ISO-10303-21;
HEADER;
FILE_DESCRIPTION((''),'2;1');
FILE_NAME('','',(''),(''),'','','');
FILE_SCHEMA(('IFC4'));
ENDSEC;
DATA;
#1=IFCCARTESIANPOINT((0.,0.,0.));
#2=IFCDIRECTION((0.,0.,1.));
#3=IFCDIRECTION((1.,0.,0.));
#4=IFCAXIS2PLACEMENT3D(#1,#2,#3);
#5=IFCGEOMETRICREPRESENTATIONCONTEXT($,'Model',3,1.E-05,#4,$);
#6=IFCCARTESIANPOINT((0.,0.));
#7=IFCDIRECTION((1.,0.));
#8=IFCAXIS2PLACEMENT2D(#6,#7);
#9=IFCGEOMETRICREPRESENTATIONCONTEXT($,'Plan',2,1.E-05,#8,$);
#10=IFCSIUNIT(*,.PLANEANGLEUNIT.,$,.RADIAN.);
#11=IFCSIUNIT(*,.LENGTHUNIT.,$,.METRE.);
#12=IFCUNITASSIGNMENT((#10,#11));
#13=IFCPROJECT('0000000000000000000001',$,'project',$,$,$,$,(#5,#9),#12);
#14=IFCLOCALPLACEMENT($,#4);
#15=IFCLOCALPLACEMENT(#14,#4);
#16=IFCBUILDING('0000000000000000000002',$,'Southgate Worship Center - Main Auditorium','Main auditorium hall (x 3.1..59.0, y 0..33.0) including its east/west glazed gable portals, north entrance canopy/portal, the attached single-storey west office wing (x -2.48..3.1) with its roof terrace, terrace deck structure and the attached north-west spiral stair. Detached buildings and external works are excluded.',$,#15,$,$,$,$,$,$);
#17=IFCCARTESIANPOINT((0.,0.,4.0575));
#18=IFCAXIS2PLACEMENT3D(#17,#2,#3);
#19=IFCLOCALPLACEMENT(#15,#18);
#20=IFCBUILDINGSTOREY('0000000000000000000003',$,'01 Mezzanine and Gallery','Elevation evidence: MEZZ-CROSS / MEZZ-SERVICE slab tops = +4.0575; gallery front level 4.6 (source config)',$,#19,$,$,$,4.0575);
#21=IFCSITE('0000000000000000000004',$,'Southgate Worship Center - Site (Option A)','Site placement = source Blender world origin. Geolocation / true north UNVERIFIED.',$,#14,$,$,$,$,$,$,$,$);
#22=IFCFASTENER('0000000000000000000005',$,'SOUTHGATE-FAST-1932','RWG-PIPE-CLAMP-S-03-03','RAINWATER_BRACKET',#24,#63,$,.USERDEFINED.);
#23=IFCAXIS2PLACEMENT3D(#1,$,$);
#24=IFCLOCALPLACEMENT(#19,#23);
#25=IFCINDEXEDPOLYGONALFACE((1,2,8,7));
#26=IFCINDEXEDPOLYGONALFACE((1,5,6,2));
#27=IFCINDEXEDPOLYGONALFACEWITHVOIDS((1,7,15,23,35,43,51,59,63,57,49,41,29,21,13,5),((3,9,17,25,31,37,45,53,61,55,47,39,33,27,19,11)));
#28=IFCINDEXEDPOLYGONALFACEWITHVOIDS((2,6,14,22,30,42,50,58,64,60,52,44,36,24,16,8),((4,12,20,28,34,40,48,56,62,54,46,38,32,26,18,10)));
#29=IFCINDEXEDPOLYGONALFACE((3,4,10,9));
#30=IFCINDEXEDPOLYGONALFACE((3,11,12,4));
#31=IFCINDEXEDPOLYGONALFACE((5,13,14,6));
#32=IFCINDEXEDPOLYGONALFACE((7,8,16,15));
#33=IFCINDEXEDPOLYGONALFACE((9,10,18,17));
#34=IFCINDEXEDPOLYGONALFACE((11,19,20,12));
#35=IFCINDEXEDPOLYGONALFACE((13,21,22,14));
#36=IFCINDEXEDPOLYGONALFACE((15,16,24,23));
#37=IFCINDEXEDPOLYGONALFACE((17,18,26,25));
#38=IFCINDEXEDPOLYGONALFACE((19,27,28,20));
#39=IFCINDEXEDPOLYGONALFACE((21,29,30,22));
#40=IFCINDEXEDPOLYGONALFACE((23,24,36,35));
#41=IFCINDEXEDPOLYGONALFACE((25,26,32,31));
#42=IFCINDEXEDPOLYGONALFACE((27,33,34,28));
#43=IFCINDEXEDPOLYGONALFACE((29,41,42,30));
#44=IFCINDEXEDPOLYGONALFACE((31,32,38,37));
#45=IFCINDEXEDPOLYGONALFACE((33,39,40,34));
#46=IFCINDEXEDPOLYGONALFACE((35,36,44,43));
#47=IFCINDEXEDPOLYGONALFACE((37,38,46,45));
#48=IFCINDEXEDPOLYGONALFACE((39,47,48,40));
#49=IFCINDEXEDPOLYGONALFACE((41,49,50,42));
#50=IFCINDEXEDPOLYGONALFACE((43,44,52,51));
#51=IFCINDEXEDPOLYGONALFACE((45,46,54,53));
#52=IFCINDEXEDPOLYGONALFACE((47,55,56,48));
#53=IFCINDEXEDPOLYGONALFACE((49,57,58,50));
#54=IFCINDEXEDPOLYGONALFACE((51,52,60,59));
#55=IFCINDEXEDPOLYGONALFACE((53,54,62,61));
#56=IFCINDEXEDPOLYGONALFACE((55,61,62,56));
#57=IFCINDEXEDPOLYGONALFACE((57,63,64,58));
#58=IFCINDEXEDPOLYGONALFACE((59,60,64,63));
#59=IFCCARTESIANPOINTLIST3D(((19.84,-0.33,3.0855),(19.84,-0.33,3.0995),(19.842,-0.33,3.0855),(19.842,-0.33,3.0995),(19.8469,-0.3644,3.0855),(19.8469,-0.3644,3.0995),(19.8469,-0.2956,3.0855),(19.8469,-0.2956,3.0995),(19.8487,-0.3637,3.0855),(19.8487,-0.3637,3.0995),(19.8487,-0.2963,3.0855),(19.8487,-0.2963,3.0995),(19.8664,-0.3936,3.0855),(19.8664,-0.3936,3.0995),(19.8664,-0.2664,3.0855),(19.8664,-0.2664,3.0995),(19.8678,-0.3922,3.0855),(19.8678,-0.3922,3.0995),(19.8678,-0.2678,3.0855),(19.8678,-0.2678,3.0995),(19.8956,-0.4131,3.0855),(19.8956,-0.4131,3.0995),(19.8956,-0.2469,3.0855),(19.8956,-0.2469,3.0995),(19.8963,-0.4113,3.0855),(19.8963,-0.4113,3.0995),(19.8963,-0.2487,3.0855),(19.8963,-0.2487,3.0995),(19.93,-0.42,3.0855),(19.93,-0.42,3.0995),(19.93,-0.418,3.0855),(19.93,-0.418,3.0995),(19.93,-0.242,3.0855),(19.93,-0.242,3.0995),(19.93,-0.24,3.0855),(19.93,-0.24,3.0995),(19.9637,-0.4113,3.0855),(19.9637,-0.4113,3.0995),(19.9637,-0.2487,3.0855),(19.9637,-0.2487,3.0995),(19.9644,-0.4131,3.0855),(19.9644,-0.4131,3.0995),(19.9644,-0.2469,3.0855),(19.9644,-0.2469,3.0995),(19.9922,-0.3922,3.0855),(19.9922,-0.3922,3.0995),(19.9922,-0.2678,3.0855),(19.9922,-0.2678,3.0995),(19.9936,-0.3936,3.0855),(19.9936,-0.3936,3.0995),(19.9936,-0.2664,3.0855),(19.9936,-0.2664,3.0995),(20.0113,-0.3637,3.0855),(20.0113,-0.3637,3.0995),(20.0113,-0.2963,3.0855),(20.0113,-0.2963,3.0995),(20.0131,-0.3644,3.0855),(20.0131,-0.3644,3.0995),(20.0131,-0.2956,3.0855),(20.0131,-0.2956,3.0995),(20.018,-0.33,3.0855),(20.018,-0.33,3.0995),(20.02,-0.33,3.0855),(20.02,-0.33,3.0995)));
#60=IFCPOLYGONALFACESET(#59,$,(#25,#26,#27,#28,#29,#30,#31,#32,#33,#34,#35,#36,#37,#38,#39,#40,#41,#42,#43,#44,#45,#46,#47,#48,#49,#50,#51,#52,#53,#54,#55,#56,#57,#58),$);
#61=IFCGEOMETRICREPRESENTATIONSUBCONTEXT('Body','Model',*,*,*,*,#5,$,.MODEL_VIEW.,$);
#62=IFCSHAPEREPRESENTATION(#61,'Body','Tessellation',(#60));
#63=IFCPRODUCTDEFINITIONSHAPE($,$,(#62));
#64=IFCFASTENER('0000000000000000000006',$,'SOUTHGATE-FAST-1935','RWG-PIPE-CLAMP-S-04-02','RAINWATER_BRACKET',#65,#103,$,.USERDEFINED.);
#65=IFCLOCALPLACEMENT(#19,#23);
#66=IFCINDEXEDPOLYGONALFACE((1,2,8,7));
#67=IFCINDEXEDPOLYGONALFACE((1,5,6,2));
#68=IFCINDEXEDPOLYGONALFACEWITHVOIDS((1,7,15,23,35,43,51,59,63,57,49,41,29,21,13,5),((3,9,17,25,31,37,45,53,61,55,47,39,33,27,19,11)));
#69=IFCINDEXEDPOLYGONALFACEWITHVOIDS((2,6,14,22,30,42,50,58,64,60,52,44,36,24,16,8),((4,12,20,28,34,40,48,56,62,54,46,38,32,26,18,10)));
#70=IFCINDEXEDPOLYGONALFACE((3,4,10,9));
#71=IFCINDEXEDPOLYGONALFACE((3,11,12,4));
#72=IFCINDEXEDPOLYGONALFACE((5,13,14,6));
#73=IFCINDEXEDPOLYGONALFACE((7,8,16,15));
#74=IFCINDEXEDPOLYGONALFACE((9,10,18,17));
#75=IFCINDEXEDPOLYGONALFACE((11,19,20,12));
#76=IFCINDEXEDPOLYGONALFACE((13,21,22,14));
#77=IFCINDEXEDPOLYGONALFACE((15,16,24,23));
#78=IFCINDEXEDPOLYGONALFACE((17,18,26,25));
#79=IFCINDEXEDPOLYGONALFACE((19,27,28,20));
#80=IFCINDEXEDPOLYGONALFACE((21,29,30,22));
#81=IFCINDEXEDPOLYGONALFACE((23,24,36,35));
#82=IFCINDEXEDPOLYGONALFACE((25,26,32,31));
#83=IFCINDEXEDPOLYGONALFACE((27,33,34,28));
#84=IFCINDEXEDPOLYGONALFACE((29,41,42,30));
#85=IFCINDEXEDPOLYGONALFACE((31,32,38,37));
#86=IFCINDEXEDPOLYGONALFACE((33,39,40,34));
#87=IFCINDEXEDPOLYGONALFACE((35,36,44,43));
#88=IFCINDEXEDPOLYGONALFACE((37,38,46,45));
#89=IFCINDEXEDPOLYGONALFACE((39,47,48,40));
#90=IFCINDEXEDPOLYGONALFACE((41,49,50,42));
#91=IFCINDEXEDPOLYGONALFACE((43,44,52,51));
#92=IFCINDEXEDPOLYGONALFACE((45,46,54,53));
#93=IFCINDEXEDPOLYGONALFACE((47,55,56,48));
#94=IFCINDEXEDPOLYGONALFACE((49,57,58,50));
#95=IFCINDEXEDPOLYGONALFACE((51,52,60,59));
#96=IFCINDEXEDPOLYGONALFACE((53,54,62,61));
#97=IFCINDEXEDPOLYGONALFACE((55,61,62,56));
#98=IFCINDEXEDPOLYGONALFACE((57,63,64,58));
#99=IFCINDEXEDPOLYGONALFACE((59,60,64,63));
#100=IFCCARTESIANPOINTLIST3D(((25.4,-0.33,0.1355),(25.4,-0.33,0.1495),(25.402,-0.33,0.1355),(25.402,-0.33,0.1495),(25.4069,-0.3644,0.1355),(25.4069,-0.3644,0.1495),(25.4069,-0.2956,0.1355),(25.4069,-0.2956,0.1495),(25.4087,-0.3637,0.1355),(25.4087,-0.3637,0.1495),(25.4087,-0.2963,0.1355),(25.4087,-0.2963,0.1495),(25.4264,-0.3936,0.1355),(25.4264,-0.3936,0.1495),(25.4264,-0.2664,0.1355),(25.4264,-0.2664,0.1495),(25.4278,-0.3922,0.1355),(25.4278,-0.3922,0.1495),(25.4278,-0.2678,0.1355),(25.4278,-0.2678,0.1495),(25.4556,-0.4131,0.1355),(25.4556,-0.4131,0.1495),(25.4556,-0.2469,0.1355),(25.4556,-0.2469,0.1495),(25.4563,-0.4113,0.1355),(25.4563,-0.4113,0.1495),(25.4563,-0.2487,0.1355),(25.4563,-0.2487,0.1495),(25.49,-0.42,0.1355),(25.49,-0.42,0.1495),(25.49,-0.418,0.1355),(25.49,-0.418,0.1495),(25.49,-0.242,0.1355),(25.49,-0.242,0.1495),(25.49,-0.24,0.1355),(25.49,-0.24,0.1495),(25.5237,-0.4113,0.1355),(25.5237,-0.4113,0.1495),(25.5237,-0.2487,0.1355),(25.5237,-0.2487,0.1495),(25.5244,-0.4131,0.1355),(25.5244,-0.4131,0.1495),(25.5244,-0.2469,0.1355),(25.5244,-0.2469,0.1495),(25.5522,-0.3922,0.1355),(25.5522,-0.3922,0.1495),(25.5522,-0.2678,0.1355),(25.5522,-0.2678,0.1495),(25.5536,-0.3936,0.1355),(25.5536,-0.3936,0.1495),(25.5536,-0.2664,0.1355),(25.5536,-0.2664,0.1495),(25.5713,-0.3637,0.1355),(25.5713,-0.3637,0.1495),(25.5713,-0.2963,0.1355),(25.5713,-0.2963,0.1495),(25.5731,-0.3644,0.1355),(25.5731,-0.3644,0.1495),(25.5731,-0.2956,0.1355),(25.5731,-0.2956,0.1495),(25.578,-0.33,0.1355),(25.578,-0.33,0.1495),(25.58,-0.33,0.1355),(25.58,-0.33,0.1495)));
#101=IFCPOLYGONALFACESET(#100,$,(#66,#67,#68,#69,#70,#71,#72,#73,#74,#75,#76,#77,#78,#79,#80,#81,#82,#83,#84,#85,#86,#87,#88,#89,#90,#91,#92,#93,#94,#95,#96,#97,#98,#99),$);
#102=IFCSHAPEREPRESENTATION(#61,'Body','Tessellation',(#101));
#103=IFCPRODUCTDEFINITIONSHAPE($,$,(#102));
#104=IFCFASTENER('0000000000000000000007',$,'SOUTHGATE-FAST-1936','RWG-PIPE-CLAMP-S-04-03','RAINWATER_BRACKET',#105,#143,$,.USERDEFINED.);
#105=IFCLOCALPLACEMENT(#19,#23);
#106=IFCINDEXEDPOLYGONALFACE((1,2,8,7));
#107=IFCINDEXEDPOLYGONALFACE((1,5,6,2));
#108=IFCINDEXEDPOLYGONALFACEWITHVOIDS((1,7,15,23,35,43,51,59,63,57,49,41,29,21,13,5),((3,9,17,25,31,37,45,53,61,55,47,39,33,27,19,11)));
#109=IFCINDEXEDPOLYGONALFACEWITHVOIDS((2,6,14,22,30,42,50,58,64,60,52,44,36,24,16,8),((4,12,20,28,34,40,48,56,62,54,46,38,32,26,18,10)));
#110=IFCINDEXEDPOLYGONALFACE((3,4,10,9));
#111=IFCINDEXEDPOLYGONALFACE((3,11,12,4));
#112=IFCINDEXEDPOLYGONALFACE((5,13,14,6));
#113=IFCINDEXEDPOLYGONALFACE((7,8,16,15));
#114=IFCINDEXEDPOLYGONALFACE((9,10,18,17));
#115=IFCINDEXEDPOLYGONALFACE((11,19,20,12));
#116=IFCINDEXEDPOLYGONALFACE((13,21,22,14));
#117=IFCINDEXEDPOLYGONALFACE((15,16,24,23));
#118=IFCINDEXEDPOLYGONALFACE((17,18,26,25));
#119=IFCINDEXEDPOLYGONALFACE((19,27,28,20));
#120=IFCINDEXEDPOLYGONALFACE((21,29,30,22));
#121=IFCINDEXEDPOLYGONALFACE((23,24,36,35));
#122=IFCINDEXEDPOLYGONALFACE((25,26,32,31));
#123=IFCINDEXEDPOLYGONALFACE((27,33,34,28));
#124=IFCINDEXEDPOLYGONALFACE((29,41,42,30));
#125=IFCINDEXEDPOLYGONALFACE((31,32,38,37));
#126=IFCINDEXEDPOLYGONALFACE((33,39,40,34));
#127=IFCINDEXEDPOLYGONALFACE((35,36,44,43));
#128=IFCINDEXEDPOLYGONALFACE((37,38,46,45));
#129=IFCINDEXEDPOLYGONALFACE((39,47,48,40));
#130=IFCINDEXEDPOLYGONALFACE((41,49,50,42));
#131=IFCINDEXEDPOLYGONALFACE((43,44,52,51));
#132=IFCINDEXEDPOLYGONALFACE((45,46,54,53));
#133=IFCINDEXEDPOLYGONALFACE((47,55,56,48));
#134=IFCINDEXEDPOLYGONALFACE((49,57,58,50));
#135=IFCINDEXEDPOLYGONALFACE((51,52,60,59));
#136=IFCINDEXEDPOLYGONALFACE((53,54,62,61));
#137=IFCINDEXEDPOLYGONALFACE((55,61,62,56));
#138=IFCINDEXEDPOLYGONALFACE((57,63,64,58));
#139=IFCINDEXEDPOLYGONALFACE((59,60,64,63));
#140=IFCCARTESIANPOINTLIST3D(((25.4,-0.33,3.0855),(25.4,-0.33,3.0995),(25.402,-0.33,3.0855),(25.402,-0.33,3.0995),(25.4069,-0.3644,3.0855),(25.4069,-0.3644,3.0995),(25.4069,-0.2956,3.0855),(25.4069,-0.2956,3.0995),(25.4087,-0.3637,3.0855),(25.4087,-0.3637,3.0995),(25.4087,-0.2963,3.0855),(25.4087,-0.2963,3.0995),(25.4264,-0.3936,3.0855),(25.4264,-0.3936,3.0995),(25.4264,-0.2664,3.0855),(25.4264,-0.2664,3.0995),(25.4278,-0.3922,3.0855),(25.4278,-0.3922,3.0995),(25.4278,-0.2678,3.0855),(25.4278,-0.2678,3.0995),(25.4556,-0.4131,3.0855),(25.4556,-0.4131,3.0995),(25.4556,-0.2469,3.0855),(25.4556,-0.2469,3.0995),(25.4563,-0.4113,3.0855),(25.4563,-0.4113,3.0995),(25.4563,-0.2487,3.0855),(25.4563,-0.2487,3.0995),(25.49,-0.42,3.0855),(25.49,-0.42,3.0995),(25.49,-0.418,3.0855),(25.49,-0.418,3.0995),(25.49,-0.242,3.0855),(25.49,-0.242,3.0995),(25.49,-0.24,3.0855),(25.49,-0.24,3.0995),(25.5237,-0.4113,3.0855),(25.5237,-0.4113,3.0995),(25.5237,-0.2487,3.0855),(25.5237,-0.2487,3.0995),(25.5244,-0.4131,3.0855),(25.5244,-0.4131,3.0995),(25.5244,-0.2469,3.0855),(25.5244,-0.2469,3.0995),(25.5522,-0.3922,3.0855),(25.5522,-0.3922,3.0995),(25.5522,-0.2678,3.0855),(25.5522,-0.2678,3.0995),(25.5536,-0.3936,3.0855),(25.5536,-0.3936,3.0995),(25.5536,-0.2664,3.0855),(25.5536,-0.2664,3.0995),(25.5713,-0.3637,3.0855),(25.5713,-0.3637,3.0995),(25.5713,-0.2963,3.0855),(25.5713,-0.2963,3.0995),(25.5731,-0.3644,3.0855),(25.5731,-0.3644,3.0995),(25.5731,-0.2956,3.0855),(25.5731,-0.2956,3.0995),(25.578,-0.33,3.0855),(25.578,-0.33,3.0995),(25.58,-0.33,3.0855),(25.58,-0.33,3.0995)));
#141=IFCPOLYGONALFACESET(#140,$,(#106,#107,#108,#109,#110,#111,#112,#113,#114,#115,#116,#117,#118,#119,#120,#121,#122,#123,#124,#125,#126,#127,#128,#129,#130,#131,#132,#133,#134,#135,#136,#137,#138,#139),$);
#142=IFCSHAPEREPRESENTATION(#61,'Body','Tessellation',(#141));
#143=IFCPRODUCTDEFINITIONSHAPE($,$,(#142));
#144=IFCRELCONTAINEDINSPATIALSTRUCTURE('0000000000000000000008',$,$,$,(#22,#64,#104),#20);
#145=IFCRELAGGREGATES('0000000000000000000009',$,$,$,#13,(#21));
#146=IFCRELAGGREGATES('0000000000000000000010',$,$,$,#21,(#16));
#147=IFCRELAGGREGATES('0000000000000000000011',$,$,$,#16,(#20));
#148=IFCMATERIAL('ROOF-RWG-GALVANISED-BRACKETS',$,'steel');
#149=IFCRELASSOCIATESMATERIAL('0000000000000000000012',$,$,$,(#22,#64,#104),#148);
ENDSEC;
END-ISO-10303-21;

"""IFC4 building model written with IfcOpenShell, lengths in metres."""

from ifc_helpers import new_model, si_unit, frame, origin_with_axes, origin_2d_with_axis, place, context, subcontext, project, spatial, indexed_curve, outline, extrude, material, element, save


model = new_model("IFC4")

# Units and contexts
model_context = context("Model", 3, precision=1e-05, world=origin_with_axes())
plan_context = context("Plan", 2, precision=1e-05, world=origin_2d_with_axis())
body_context = subcontext(model_context, "Body", "Model", "MODEL_VIEW")
ifc_project = project(units=[si_unit("PLANEANGLEUNIT", "RADIAN"), si_unit("LENGTHUNIT", "METRE")], contexts=[model_context, plan_context])

# Site, building, storey
site_placement = place(None, origin_with_axes())
site = spatial("IfcSite", under=ifc_project, at=site_placement, Name="Southgate Worship Center - Site (Option A)", Description="Site placement = source Blender world origin. Geolocation / true north UNVERIFIED.")
building_placement = place(site_placement, origin_with_axes())
building = spatial("IfcBuilding", under=site, at=building_placement, Name="Southgate Worship Center - Main Auditorium", Description="Main auditorium hall (x 3.1..59.0, y 0..33.0) including its east/west glazed gable portals, north entrance canopy/portal, the attached single-storey west office wing (x -2.48..3.1) with its roof terrace, terrace deck structure and the attached north-west spiral stair. Detached buildings and external works are excluded.")
storey_placement = place(building_placement, frame((0.0, 0.0, 4.0575), z_axis=(0.0, 0.0, 1.0), x_axis=(1.0, 0.0, 0.0)))
storey = spatial("IfcBuildingStorey", under=building, at=storey_placement, Name="01 Mezzanine and Gallery", Description="Elevation evidence: MEZZ-CROSS / MEZZ-SERVICE slab tops = +4.0575; gallery front level 4.6 (source config)", Elevation=4.0575)

# Fasteners
ifc_material_1 = material(Name="ROOF-RWG-GALVANISED-BRACKETS", Category="steel")
fastener_1_placement = place(storey_placement, frame((19.84, -0.42, 3.0855), z_axis=(0.0, 0.0, 1.0), x_axis=(1.0, 0.0, 0.0)))
element("IfcFastener", 1, at=fastener_1_placement, inside=storey, material=ifc_material_1, Name="SOUTHGATE-FAST-1932", Description="RWG-PIPE-CLAMP-S-03-03", ObjectType="RAINWATER_BRACKET", PredefinedType="USERDEFINED", context=body_context, shape_type="SweptSolid", body=[
    extrude(outline(indexed_curve([(0.0, 0.0), (0.0069, 0.0344), (0.0, 0.0689), (-0.0195, 0.0981), (-0.0487, 0.1176), (-0.0831, 0.1244), (-0.1176, 0.1176), (-0.1468, 0.0981), (-0.1663, 0.0689), (-0.1731, 0.0344), (-0.1663, 0.0), (-0.1468, -0.0292), (-0.1176, -0.0487), (-0.0831, -0.0556), (-0.0487, -0.0487), (-0.0195, -0.0292), (0.0, 0.0)], self_intersect=False), holes=[indexed_curve([(-0.1454, -0.0278), (-0.1644, 0.0008), (-0.1711, 0.0344), (-0.1644, 0.0681), (-0.1454, 0.0967), (-0.1168, 0.1157), (-0.0831, 0.1224), (-0.0495, 0.1157), (-0.0209, 0.0967), (-0.0018, 0.0681), (0.0049, 0.0344), (-0.0018, 0.0008), (-0.0209, -0.0278), (-0.0495, -0.0469), (-0.0831, -0.0536), (-0.1168, -0.0469), (-0.1454, -0.0278)], self_intersect=False)]), frame((0.1731, 0.0556, 0.0), z_axis=(0.0, 0.0, 1.0), x_axis=(1.0, 0.0, 0.0)), (0.0, 0.0, 1.0), 0.014),
])
fastener_2_placement = place(storey_placement, frame((25.4, -0.42, 0.1355), z_axis=(0.0, 0.0, 1.0), x_axis=(1.0, 0.0, 0.0)))
element("IfcFastener", 2, at=fastener_2_placement, inside=storey, material=ifc_material_1, Name="SOUTHGATE-FAST-1935", Description="RWG-PIPE-CLAMP-S-04-02", ObjectType="RAINWATER_BRACKET", PredefinedType="USERDEFINED", context=body_context, shape_type="SweptSolid", body=[
    extrude(outline(indexed_curve([(0.0, 0.0), (0.0069, 0.0344), (0.0, 0.0689), (-0.0195, 0.0981), (-0.0487, 0.1176), (-0.0831, 0.1244), (-0.1176, 0.1176), (-0.1468, 0.0981), (-0.1663, 0.0689), (-0.1731, 0.0344), (-0.1663, 0.0), (-0.1468, -0.0292), (-0.1176, -0.0487), (-0.0831, -0.0556), (-0.0487, -0.0487), (-0.0195, -0.0292), (0.0, 0.0)], self_intersect=False), holes=[indexed_curve([(-0.1454, -0.0278), (-0.1644, 0.0008), (-0.1711, 0.0344), (-0.1644, 0.0681), (-0.1454, 0.0967), (-0.1168, 0.1157), (-0.0831, 0.1224), (-0.0495, 0.1157), (-0.0209, 0.0967), (-0.0018, 0.0681), (0.0049, 0.0344), (-0.0018, 0.0008), (-0.0209, -0.0278), (-0.0495, -0.0469), (-0.0831, -0.0536), (-0.1168, -0.0469), (-0.1454, -0.0278)], self_intersect=False)]), frame((0.1731, 0.0556, 0.0), z_axis=(0.0, 0.0, 1.0), x_axis=(1.0, 0.0, 0.0)), (0.0, 0.0, 1.0), 0.014),
])
fastener_3_placement = place(storey_placement, frame((25.4, -0.42, 3.0855), z_axis=(0.0, 0.0, 1.0), x_axis=(1.0, 0.0, 0.0)))
element("IfcFastener", 3, at=fastener_3_placement, inside=storey, material=ifc_material_1, Name="SOUTHGATE-FAST-1936", Description="RWG-PIPE-CLAMP-S-04-03", ObjectType="RAINWATER_BRACKET", PredefinedType="USERDEFINED", context=body_context, shape_type="SweptSolid", body=[
    extrude(outline(indexed_curve([(0.0, 0.0), (0.0069, 0.0344), (0.0, 0.0689), (-0.0195, 0.0981), (-0.0487, 0.1176), (-0.0831, 0.1244), (-0.1176, 0.1176), (-0.1468, 0.0981), (-0.1663, 0.0689), (-0.1731, 0.0344), (-0.1663, 0.0), (-0.1468, -0.0292), (-0.1176, -0.0487), (-0.0831, -0.0556), (-0.0487, -0.0487), (-0.0195, -0.0292), (0.0, 0.0)], self_intersect=False), holes=[indexed_curve([(-0.1454, -0.0278), (-0.1644, 0.0008), (-0.1711, 0.0344), (-0.1644, 0.0681), (-0.1454, 0.0967), (-0.1168, 0.1157), (-0.0831, 0.1224), (-0.0495, 0.1157), (-0.0209, 0.0967), (-0.0018, 0.0681), (0.0049, 0.0344), (-0.0018, 0.0008), (-0.0209, -0.0278), (-0.0495, -0.0469), (-0.0831, -0.0536), (-0.1168, -0.0469), (-0.1454, -0.0278)], self_intersect=False)]), frame((0.1731, 0.0556, 0.0), z_axis=(0.0, 0.0, 1.0), x_axis=(1.0, 0.0, 0.0)), (0.0, 0.0, 1.0), 0.014),
])

save(model, "model.ifc")
